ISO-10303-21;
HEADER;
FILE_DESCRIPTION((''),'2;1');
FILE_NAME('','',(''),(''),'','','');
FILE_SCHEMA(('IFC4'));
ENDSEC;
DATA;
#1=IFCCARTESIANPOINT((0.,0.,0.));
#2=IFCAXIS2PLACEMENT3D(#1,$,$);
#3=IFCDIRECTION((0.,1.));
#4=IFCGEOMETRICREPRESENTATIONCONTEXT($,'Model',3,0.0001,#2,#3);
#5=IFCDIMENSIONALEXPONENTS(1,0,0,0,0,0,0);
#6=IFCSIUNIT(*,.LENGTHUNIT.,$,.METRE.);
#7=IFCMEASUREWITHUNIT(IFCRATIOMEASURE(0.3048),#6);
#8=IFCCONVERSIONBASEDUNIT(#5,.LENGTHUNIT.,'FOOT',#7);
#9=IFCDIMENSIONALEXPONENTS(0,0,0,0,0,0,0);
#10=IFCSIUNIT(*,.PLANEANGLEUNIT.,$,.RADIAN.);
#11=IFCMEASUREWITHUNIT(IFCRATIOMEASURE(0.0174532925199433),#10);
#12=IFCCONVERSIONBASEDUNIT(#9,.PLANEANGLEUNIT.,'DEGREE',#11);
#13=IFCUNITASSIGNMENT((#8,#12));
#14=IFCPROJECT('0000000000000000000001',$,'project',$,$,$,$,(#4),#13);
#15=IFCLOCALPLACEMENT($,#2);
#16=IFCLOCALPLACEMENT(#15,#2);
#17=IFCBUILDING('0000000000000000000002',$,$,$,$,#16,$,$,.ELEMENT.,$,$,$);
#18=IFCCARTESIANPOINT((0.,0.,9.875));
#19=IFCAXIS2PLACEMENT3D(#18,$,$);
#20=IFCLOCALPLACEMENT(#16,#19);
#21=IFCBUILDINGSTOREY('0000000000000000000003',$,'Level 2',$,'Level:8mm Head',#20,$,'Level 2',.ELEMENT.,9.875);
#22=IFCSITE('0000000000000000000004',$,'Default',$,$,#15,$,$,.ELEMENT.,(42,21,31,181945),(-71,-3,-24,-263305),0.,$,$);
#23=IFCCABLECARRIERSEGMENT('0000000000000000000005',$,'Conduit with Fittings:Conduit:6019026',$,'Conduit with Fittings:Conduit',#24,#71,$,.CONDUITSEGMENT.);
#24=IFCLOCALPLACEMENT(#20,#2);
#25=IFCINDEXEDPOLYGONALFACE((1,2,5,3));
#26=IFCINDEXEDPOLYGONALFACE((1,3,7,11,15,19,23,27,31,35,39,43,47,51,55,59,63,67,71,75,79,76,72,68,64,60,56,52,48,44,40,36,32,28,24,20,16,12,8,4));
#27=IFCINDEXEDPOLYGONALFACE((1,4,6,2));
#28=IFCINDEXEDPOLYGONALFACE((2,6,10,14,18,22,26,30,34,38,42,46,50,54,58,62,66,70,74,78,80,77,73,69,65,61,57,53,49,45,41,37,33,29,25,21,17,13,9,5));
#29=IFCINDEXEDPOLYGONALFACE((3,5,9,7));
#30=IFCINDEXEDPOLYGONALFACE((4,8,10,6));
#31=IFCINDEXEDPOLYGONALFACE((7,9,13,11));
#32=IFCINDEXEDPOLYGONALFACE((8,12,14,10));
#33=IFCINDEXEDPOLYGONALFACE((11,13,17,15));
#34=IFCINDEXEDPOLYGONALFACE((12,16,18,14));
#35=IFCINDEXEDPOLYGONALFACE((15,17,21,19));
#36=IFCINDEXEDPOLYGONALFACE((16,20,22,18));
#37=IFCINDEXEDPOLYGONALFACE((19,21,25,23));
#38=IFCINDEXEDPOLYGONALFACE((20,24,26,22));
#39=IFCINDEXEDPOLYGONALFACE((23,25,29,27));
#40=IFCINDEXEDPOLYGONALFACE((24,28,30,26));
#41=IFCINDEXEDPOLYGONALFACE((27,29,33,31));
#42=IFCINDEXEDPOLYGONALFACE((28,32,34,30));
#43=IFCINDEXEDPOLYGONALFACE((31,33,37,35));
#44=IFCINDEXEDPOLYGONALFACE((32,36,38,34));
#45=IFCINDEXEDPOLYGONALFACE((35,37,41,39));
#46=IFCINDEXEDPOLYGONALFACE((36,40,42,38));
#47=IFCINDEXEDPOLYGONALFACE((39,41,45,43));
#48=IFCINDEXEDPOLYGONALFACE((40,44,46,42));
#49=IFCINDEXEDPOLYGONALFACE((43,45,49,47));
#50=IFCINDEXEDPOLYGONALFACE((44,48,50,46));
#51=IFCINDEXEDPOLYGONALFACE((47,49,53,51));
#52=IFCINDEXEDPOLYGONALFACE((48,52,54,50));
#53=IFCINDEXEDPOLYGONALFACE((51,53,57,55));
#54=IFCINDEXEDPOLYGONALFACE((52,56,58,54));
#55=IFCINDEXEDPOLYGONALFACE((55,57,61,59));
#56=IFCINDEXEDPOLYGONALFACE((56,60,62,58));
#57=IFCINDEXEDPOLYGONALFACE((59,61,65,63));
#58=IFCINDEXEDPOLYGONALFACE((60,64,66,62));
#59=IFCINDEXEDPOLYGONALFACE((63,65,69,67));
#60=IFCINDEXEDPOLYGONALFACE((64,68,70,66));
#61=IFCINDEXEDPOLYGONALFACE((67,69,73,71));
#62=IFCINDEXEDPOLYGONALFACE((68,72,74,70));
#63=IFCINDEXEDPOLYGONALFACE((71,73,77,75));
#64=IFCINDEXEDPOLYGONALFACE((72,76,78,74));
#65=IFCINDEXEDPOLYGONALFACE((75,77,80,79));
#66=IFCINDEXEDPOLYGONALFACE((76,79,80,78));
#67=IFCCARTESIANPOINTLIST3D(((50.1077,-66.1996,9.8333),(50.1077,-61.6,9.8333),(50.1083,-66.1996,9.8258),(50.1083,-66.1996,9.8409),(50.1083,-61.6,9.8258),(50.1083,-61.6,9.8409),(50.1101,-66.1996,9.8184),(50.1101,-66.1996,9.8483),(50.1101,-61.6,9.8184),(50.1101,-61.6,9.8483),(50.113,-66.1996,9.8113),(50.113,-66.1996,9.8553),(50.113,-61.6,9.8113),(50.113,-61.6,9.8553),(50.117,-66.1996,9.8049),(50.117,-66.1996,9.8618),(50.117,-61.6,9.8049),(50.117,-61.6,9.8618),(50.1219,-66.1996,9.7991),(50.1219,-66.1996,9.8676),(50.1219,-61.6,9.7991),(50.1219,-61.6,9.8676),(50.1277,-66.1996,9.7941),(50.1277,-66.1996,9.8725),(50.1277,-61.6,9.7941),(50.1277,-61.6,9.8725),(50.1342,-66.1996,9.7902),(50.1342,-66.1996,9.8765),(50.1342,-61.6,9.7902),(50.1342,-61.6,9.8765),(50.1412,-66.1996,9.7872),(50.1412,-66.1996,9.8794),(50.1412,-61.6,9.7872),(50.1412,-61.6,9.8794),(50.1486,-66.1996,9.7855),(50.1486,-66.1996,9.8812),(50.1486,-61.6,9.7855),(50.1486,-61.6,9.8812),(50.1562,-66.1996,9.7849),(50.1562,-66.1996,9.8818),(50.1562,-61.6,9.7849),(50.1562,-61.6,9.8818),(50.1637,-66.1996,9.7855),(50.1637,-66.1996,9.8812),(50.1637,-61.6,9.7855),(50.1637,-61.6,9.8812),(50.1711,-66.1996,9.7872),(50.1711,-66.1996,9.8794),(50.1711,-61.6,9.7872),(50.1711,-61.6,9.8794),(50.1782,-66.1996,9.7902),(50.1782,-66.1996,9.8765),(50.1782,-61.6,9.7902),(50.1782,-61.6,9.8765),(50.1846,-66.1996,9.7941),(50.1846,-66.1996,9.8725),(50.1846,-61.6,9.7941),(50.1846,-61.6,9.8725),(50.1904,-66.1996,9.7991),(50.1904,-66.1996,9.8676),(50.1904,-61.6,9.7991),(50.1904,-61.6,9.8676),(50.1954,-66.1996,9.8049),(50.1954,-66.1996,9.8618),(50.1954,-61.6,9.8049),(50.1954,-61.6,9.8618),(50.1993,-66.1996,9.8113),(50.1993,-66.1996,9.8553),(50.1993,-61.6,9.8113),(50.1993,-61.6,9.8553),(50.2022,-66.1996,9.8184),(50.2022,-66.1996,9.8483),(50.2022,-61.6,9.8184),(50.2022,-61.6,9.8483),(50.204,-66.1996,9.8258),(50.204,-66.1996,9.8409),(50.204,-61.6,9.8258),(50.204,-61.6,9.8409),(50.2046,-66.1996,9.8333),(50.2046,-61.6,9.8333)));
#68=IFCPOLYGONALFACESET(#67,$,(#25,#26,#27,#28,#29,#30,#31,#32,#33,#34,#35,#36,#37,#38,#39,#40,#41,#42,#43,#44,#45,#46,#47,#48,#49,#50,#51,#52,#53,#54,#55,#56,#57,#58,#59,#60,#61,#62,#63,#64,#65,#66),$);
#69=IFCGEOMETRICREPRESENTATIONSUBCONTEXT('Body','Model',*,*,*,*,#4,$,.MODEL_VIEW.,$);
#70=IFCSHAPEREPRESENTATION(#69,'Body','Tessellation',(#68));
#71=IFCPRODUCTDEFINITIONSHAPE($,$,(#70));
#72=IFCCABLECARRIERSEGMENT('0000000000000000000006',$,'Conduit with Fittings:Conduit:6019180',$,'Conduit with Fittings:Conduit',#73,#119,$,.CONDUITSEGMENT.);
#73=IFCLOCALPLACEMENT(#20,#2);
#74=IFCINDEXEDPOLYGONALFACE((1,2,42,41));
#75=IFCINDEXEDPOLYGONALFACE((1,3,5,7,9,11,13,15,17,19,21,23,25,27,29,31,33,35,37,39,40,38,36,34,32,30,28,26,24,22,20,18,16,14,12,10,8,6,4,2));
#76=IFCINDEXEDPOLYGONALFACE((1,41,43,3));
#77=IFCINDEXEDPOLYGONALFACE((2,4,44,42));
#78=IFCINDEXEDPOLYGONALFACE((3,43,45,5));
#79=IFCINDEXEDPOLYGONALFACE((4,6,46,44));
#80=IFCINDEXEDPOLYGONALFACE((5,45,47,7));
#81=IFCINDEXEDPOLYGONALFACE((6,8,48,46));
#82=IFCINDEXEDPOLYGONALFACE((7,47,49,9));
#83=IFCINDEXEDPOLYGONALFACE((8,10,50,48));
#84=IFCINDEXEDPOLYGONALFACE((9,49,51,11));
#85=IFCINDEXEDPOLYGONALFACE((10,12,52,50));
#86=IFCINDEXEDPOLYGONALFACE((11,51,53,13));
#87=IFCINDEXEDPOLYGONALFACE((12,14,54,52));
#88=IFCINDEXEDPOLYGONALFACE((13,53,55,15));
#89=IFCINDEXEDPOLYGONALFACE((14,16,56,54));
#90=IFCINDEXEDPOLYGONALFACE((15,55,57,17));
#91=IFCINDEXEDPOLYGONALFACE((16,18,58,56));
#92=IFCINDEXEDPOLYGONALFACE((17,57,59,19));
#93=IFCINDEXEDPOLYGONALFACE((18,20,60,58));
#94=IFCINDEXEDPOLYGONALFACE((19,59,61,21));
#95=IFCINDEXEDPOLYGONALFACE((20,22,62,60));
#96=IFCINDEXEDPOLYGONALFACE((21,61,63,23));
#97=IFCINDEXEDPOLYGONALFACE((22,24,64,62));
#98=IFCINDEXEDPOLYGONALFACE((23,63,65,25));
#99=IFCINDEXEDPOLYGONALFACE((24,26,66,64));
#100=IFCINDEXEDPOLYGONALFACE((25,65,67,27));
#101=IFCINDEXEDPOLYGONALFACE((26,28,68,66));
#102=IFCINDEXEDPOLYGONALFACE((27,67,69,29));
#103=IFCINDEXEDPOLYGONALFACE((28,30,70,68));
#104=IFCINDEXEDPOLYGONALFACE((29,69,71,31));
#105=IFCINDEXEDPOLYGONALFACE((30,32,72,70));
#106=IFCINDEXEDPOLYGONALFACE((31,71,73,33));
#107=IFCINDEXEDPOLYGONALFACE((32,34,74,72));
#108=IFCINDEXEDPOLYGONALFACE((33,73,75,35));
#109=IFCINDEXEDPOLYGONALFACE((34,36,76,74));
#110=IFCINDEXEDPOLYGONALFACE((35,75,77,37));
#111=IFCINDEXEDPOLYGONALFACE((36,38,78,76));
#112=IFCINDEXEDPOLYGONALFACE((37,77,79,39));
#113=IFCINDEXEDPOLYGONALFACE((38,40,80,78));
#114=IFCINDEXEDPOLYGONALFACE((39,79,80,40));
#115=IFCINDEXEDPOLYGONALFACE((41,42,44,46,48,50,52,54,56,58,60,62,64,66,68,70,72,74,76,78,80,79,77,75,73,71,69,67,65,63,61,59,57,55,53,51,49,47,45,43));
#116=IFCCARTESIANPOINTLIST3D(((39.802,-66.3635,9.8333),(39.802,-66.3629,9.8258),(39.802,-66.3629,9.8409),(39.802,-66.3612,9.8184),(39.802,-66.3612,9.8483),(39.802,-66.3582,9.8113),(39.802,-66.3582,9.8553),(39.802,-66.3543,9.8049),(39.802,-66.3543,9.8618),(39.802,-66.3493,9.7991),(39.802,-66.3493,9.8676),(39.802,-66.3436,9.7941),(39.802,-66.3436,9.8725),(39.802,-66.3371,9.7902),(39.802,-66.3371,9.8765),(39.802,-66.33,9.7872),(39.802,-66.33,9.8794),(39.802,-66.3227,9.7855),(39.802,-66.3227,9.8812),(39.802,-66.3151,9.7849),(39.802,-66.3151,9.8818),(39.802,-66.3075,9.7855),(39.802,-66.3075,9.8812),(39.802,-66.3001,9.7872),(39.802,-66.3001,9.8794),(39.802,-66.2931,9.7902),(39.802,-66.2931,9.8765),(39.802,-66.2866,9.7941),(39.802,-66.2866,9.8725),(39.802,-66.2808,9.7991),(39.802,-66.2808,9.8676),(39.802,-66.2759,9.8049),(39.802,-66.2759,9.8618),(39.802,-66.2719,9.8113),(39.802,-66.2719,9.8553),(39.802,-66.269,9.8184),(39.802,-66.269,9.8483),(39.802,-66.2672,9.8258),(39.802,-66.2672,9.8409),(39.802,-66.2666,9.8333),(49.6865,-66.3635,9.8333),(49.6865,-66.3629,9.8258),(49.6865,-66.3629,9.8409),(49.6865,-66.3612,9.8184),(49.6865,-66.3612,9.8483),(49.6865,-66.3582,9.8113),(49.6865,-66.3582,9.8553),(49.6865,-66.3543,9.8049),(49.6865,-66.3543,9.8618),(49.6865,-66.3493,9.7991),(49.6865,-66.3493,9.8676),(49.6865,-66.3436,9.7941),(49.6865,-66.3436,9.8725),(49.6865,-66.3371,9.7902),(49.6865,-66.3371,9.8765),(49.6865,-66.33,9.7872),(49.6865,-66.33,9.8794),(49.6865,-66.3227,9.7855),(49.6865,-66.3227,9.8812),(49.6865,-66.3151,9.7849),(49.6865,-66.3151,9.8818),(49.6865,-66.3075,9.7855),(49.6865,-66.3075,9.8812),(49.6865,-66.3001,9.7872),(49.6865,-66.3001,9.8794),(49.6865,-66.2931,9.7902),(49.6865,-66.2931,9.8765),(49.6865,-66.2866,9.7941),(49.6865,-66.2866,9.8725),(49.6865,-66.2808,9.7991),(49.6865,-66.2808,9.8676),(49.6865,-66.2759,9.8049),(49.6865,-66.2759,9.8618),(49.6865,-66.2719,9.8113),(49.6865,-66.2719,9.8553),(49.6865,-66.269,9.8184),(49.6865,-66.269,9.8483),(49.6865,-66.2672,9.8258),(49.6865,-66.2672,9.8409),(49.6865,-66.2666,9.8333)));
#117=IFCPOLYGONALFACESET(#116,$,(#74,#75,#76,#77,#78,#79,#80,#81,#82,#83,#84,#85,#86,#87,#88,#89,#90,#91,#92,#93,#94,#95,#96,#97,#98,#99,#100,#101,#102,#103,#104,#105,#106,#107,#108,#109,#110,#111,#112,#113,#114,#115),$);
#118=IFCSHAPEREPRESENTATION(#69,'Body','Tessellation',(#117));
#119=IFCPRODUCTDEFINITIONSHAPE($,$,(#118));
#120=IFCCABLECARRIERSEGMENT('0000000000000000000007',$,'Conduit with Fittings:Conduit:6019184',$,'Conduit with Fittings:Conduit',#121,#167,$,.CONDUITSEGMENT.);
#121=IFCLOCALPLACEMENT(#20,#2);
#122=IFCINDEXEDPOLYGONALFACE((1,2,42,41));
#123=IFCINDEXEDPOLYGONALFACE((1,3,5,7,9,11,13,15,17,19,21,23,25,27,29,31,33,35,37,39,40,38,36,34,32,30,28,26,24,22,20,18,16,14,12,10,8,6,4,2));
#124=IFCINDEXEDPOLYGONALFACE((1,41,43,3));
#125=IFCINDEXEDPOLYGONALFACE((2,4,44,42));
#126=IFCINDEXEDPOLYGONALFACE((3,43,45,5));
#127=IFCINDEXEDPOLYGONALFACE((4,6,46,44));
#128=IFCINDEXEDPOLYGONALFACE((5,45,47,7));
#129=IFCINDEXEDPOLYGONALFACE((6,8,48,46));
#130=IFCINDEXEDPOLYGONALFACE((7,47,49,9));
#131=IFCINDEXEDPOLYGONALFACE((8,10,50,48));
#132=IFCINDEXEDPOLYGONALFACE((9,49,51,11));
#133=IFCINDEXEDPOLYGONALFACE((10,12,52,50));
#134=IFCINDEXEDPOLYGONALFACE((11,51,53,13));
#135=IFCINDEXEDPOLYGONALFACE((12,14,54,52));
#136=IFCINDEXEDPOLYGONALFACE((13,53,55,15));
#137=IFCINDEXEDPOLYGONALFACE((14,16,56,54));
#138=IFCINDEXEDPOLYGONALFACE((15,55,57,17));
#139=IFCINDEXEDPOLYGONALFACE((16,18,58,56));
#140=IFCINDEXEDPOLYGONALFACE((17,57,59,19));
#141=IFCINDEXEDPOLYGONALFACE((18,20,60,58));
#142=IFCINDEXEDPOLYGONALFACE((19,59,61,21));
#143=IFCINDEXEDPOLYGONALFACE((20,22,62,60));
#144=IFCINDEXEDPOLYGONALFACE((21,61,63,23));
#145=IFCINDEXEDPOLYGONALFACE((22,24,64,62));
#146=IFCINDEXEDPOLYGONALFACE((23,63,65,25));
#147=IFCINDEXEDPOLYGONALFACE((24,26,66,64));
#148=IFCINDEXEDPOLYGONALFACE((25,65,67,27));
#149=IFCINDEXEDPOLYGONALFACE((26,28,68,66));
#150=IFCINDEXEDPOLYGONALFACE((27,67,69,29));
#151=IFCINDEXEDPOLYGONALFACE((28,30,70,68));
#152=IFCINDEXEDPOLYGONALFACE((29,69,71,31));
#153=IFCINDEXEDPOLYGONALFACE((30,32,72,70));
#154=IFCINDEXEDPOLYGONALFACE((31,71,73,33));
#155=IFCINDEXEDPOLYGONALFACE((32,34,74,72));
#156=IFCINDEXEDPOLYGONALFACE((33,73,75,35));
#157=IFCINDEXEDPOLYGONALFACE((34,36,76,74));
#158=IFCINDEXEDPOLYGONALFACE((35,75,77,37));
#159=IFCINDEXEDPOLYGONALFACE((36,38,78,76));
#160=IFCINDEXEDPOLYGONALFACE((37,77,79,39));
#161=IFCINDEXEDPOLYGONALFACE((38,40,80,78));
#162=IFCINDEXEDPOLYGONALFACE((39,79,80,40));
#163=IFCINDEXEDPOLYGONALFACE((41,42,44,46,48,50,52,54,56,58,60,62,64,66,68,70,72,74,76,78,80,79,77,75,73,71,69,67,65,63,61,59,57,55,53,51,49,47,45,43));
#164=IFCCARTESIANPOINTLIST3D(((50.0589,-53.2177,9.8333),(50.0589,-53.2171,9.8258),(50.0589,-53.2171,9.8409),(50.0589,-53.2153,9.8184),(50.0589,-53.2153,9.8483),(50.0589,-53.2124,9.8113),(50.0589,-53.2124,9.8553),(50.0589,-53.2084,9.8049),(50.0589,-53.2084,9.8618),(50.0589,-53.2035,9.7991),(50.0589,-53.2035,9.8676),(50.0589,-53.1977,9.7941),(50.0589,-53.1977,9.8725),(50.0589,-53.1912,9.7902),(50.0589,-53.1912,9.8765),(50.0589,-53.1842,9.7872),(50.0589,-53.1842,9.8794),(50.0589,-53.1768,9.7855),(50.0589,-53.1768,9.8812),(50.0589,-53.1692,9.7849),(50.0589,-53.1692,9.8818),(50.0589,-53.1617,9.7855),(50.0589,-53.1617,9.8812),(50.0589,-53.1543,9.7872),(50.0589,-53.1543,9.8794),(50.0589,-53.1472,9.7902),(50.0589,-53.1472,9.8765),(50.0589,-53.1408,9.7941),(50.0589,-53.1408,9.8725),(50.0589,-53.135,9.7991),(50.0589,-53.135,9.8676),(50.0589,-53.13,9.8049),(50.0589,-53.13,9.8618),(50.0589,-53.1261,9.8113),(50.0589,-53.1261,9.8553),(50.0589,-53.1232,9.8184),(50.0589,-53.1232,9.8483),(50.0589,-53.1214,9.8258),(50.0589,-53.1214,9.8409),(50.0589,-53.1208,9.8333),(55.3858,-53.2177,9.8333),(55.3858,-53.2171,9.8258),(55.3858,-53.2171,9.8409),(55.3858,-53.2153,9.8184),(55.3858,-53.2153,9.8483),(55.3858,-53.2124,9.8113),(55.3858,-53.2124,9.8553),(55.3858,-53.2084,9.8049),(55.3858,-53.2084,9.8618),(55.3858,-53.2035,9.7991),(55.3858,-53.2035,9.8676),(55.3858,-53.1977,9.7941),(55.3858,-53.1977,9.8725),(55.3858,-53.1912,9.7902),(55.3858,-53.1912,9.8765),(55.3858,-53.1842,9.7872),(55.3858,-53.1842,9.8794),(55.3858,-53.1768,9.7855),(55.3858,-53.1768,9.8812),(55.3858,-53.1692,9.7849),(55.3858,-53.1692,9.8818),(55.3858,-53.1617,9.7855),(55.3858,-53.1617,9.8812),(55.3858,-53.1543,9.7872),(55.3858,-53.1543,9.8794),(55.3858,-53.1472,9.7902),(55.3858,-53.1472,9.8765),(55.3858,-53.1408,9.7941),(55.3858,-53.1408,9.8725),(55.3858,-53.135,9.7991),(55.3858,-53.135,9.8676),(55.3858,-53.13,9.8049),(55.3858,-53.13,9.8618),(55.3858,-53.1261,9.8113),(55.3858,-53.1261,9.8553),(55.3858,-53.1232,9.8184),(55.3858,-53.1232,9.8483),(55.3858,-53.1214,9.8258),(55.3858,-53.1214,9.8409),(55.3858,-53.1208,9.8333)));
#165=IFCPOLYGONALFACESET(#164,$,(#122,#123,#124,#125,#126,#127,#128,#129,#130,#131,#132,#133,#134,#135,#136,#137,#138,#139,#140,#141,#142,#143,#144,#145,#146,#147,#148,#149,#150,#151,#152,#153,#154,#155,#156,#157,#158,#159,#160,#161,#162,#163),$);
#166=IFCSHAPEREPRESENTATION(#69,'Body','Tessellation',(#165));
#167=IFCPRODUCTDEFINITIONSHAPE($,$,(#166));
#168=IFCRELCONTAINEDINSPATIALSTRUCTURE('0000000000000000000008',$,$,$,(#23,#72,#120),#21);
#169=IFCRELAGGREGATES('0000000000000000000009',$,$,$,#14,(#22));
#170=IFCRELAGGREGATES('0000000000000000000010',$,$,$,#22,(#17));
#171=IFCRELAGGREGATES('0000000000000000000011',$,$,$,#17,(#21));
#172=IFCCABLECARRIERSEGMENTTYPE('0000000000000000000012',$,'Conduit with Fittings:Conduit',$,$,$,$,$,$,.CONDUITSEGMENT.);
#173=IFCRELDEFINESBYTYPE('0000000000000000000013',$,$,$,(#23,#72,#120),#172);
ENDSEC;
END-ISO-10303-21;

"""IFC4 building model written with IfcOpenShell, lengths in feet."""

from ifc_helpers import new_model, entity, si_unit, converted_unit, direction, frame, origin, place, context, subcontext, project, spatial, indexed_curve, outline, extrude, type_object, element, save


model = new_model("IFC4")

# Units and contexts
model_context = context("Model", 3, precision=0.0001, world=origin(), true_north=direction((0.0, 1.0)))
body_context = subcontext(model_context, "Body", "Model", "MODEL_VIEW")
ifc_project = project(units=[converted_unit("LENGTHUNIT", "FOOT", entity("IfcRatioMeasure", 0.3048), si_unit("LENGTHUNIT", "METRE"), dimensions=[1, 0, 0, 0, 0, 0, 0]), converted_unit("PLANEANGLEUNIT", "DEGREE", entity("IfcRatioMeasure", 0.0174532925199433), si_unit("PLANEANGLEUNIT", "RADIAN"), dimensions=[0, 0, 0, 0, 0, 0, 0])], contexts=[model_context])

# Site, building, storey
site_placement = place(None, origin())
site = spatial("IfcSite", under=ifc_project, at=site_placement, Name="Default", CompositionType="ELEMENT", RefLatitude=(42, 21, 31, 181945), RefLongitude=(-71, -3, -24, -263305), RefElevation=0.0)
building_placement = place(site_placement, origin())
building = spatial("IfcBuilding", under=site, at=building_placement, CompositionType="ELEMENT")
storey_placement = place(building_placement, frame((0.0, 0.0, 9.875)))
storey = spatial("IfcBuildingStorey", under=building, at=storey_placement, Name="Level 2", ObjectType="Level:8mm Head", LongName="Level 2", CompositionType="ELEMENT", Elevation=9.875)

# Cable carrier segments
cable_carrier_segment_type = type_object("IfcCableCarrierSegmentType", Name="Conduit with Fittings:Conduit", PredefinedType="CONDUITSEGMENT")
cable_carrier_segment_1_placement = place(storey_placement, origin())
element("IfcCableCarrierSegment", 1, at=cable_carrier_segment_1_placement, inside=storey, type_object=cable_carrier_segment_type, Name="Conduit with Fittings:Conduit:6019026", ObjectType="Conduit with Fittings:Conduit", PredefinedType="CONDUITSEGMENT", context=body_context, shape_type="SweptSolid", body=[
    extrude(outline(indexed_curve([(0.0485, 0.0), (0.0479, 0.0076), (0.0461, 0.015), (0.0432, 0.022), (0.0392, 0.0285), (0.0343, 0.0343), (0.0285, 0.0392), (0.022, 0.0432), (0.015, 0.0461), (0.0076, 0.0479), (0.0, 0.0485), (-0.0076, 0.0479), (-0.015, 0.0461), (-0.022, 0.0432), (-0.0285, 0.0392), (-0.0343, 0.0343), (-0.0392, 0.0285), (-0.0432, 0.022), (-0.0461, 0.015), (-0.0479, 0.0076), (-0.0485, 0.0), (-0.0479, -0.0076), (-0.0461, -0.015), (-0.0432, -0.022), (-0.0392, -0.0285), (-0.0343, -0.0343), (-0.0285, -0.0392), (-0.022, -0.0432), (-0.015, -0.0461), (-0.0076, -0.0479), (0.0, -0.0485), (0.0076, -0.0479), (0.015, -0.0461), (0.022, -0.0432), (0.0285, -0.0392), (0.0343, -0.0343), (0.0392, -0.0285), (0.0432, -0.022), (0.0461, -0.015), (0.0479, -0.0076), (0.0485, 0.0)], self_intersect=False)), frame((50.1562, -66.1996, 9.8333), z_axis=(0.0, 1.0, 0.0), x_axis=(1.0, 0.0, 0.0)), (0.0, 0.0, 1.0), 4.5995),
])
cable_carrier_segment_2_placement = place(storey_placement, origin())
element("IfcCableCarrierSegment", 2, at=cable_carrier_segment_2_placement, inside=storey, type_object=cable_carrier_segment_type, Name="Conduit with Fittings:Conduit:6019180", ObjectType="Conduit with Fittings:Conduit", PredefinedType="CONDUITSEGMENT", context=body_context, shape_type="SweptSolid", body=[
    extrude(outline(indexed_curve([(0.0485, 0.0), (0.0479, 0.0076), (0.0461, 0.015), (0.0432, 0.022), (0.0392, 0.0285), (0.0343, 0.0343), (0.0285, 0.0392), (0.022, 0.0432), (0.015, 0.0461), (0.0076, 0.0479), (0.0, 0.0485), (-0.0076, 0.0479), (-0.015, 0.0461), (-0.022, 0.0432), (-0.0285, 0.0392), (-0.0343, 0.0343), (-0.0392, 0.0285), (-0.0432, 0.022), (-0.0461, 0.015), (-0.0479, 0.0076), (-0.0485, 0.0), (-0.0479, -0.0076), (-0.0461, -0.015), (-0.0432, -0.022), (-0.0392, -0.0285), (-0.0343, -0.0343), (-0.0285, -0.0392), (-0.022, -0.0432), (-0.015, -0.0461), (-0.0076, -0.0479), (0.0, -0.0485), (0.0076, -0.0479), (0.015, -0.0461), (0.022, -0.0432), (0.0285, -0.0392), (0.0343, -0.0343), (0.0392, -0.0285), (0.0432, -0.022), (0.0461, -0.015), (0.0479, -0.0076), (0.0485, 0.0)], self_intersect=False)), frame((39.802, -66.3151, 9.8333), z_axis=(1.0, 0.0, 0.0), x_axis=(0.0, 1.0, 0.0)), (0.0, 0.0, 1.0), 9.8845),
])
cable_carrier_segment_3_placement = place(storey_placement, origin())
element("IfcCableCarrierSegment", 3, at=cable_carrier_segment_3_placement, inside=storey, type_object=cable_carrier_segment_type, Name="Conduit with Fittings:Conduit:6019184", ObjectType="Conduit with Fittings:Conduit", PredefinedType="CONDUITSEGMENT", context=body_context, shape_type="SweptSolid", body=[
    extrude(outline(indexed_curve([(0.0485, 0.0), (0.0479, 0.0076), (0.0461, 0.015), (0.0432, 0.022), (0.0392, 0.0285), (0.0343, 0.0343), (0.0285, 0.0392), (0.022, 0.0432), (0.015, 0.0461), (0.0076, 0.0479), (0.0, 0.0485), (-0.0076, 0.0479), (-0.015, 0.0461), (-0.022, 0.0432), (-0.0285, 0.0392), (-0.0343, 0.0343), (-0.0392, 0.0285), (-0.0432, 0.022), (-0.0461, 0.015), (-0.0479, 0.0076), (-0.0485, 0.0), (-0.0479, -0.0076), (-0.0461, -0.015), (-0.0432, -0.022), (-0.0392, -0.0285), (-0.0343, -0.0343), (-0.0285, -0.0392), (-0.022, -0.0432), (-0.015, -0.0461), (-0.0076, -0.0479), (0.0, -0.0485), (0.0076, -0.0479), (0.015, -0.0461), (0.022, -0.0432), (0.0285, -0.0392), (0.0343, -0.0343), (0.0392, -0.0285), (0.0432, -0.022), (0.0461, -0.015), (0.0479, -0.0076), (0.0485, 0.0)], self_intersect=False)), frame((50.0589, -53.1692, 9.8333), z_axis=(1.0, 0.0, 0.0), x_axis=(0.0, -1.0, 0.0)), (0.0, 0.0, 1.0), 5.3269),
])

save(model, "model.ifc")
